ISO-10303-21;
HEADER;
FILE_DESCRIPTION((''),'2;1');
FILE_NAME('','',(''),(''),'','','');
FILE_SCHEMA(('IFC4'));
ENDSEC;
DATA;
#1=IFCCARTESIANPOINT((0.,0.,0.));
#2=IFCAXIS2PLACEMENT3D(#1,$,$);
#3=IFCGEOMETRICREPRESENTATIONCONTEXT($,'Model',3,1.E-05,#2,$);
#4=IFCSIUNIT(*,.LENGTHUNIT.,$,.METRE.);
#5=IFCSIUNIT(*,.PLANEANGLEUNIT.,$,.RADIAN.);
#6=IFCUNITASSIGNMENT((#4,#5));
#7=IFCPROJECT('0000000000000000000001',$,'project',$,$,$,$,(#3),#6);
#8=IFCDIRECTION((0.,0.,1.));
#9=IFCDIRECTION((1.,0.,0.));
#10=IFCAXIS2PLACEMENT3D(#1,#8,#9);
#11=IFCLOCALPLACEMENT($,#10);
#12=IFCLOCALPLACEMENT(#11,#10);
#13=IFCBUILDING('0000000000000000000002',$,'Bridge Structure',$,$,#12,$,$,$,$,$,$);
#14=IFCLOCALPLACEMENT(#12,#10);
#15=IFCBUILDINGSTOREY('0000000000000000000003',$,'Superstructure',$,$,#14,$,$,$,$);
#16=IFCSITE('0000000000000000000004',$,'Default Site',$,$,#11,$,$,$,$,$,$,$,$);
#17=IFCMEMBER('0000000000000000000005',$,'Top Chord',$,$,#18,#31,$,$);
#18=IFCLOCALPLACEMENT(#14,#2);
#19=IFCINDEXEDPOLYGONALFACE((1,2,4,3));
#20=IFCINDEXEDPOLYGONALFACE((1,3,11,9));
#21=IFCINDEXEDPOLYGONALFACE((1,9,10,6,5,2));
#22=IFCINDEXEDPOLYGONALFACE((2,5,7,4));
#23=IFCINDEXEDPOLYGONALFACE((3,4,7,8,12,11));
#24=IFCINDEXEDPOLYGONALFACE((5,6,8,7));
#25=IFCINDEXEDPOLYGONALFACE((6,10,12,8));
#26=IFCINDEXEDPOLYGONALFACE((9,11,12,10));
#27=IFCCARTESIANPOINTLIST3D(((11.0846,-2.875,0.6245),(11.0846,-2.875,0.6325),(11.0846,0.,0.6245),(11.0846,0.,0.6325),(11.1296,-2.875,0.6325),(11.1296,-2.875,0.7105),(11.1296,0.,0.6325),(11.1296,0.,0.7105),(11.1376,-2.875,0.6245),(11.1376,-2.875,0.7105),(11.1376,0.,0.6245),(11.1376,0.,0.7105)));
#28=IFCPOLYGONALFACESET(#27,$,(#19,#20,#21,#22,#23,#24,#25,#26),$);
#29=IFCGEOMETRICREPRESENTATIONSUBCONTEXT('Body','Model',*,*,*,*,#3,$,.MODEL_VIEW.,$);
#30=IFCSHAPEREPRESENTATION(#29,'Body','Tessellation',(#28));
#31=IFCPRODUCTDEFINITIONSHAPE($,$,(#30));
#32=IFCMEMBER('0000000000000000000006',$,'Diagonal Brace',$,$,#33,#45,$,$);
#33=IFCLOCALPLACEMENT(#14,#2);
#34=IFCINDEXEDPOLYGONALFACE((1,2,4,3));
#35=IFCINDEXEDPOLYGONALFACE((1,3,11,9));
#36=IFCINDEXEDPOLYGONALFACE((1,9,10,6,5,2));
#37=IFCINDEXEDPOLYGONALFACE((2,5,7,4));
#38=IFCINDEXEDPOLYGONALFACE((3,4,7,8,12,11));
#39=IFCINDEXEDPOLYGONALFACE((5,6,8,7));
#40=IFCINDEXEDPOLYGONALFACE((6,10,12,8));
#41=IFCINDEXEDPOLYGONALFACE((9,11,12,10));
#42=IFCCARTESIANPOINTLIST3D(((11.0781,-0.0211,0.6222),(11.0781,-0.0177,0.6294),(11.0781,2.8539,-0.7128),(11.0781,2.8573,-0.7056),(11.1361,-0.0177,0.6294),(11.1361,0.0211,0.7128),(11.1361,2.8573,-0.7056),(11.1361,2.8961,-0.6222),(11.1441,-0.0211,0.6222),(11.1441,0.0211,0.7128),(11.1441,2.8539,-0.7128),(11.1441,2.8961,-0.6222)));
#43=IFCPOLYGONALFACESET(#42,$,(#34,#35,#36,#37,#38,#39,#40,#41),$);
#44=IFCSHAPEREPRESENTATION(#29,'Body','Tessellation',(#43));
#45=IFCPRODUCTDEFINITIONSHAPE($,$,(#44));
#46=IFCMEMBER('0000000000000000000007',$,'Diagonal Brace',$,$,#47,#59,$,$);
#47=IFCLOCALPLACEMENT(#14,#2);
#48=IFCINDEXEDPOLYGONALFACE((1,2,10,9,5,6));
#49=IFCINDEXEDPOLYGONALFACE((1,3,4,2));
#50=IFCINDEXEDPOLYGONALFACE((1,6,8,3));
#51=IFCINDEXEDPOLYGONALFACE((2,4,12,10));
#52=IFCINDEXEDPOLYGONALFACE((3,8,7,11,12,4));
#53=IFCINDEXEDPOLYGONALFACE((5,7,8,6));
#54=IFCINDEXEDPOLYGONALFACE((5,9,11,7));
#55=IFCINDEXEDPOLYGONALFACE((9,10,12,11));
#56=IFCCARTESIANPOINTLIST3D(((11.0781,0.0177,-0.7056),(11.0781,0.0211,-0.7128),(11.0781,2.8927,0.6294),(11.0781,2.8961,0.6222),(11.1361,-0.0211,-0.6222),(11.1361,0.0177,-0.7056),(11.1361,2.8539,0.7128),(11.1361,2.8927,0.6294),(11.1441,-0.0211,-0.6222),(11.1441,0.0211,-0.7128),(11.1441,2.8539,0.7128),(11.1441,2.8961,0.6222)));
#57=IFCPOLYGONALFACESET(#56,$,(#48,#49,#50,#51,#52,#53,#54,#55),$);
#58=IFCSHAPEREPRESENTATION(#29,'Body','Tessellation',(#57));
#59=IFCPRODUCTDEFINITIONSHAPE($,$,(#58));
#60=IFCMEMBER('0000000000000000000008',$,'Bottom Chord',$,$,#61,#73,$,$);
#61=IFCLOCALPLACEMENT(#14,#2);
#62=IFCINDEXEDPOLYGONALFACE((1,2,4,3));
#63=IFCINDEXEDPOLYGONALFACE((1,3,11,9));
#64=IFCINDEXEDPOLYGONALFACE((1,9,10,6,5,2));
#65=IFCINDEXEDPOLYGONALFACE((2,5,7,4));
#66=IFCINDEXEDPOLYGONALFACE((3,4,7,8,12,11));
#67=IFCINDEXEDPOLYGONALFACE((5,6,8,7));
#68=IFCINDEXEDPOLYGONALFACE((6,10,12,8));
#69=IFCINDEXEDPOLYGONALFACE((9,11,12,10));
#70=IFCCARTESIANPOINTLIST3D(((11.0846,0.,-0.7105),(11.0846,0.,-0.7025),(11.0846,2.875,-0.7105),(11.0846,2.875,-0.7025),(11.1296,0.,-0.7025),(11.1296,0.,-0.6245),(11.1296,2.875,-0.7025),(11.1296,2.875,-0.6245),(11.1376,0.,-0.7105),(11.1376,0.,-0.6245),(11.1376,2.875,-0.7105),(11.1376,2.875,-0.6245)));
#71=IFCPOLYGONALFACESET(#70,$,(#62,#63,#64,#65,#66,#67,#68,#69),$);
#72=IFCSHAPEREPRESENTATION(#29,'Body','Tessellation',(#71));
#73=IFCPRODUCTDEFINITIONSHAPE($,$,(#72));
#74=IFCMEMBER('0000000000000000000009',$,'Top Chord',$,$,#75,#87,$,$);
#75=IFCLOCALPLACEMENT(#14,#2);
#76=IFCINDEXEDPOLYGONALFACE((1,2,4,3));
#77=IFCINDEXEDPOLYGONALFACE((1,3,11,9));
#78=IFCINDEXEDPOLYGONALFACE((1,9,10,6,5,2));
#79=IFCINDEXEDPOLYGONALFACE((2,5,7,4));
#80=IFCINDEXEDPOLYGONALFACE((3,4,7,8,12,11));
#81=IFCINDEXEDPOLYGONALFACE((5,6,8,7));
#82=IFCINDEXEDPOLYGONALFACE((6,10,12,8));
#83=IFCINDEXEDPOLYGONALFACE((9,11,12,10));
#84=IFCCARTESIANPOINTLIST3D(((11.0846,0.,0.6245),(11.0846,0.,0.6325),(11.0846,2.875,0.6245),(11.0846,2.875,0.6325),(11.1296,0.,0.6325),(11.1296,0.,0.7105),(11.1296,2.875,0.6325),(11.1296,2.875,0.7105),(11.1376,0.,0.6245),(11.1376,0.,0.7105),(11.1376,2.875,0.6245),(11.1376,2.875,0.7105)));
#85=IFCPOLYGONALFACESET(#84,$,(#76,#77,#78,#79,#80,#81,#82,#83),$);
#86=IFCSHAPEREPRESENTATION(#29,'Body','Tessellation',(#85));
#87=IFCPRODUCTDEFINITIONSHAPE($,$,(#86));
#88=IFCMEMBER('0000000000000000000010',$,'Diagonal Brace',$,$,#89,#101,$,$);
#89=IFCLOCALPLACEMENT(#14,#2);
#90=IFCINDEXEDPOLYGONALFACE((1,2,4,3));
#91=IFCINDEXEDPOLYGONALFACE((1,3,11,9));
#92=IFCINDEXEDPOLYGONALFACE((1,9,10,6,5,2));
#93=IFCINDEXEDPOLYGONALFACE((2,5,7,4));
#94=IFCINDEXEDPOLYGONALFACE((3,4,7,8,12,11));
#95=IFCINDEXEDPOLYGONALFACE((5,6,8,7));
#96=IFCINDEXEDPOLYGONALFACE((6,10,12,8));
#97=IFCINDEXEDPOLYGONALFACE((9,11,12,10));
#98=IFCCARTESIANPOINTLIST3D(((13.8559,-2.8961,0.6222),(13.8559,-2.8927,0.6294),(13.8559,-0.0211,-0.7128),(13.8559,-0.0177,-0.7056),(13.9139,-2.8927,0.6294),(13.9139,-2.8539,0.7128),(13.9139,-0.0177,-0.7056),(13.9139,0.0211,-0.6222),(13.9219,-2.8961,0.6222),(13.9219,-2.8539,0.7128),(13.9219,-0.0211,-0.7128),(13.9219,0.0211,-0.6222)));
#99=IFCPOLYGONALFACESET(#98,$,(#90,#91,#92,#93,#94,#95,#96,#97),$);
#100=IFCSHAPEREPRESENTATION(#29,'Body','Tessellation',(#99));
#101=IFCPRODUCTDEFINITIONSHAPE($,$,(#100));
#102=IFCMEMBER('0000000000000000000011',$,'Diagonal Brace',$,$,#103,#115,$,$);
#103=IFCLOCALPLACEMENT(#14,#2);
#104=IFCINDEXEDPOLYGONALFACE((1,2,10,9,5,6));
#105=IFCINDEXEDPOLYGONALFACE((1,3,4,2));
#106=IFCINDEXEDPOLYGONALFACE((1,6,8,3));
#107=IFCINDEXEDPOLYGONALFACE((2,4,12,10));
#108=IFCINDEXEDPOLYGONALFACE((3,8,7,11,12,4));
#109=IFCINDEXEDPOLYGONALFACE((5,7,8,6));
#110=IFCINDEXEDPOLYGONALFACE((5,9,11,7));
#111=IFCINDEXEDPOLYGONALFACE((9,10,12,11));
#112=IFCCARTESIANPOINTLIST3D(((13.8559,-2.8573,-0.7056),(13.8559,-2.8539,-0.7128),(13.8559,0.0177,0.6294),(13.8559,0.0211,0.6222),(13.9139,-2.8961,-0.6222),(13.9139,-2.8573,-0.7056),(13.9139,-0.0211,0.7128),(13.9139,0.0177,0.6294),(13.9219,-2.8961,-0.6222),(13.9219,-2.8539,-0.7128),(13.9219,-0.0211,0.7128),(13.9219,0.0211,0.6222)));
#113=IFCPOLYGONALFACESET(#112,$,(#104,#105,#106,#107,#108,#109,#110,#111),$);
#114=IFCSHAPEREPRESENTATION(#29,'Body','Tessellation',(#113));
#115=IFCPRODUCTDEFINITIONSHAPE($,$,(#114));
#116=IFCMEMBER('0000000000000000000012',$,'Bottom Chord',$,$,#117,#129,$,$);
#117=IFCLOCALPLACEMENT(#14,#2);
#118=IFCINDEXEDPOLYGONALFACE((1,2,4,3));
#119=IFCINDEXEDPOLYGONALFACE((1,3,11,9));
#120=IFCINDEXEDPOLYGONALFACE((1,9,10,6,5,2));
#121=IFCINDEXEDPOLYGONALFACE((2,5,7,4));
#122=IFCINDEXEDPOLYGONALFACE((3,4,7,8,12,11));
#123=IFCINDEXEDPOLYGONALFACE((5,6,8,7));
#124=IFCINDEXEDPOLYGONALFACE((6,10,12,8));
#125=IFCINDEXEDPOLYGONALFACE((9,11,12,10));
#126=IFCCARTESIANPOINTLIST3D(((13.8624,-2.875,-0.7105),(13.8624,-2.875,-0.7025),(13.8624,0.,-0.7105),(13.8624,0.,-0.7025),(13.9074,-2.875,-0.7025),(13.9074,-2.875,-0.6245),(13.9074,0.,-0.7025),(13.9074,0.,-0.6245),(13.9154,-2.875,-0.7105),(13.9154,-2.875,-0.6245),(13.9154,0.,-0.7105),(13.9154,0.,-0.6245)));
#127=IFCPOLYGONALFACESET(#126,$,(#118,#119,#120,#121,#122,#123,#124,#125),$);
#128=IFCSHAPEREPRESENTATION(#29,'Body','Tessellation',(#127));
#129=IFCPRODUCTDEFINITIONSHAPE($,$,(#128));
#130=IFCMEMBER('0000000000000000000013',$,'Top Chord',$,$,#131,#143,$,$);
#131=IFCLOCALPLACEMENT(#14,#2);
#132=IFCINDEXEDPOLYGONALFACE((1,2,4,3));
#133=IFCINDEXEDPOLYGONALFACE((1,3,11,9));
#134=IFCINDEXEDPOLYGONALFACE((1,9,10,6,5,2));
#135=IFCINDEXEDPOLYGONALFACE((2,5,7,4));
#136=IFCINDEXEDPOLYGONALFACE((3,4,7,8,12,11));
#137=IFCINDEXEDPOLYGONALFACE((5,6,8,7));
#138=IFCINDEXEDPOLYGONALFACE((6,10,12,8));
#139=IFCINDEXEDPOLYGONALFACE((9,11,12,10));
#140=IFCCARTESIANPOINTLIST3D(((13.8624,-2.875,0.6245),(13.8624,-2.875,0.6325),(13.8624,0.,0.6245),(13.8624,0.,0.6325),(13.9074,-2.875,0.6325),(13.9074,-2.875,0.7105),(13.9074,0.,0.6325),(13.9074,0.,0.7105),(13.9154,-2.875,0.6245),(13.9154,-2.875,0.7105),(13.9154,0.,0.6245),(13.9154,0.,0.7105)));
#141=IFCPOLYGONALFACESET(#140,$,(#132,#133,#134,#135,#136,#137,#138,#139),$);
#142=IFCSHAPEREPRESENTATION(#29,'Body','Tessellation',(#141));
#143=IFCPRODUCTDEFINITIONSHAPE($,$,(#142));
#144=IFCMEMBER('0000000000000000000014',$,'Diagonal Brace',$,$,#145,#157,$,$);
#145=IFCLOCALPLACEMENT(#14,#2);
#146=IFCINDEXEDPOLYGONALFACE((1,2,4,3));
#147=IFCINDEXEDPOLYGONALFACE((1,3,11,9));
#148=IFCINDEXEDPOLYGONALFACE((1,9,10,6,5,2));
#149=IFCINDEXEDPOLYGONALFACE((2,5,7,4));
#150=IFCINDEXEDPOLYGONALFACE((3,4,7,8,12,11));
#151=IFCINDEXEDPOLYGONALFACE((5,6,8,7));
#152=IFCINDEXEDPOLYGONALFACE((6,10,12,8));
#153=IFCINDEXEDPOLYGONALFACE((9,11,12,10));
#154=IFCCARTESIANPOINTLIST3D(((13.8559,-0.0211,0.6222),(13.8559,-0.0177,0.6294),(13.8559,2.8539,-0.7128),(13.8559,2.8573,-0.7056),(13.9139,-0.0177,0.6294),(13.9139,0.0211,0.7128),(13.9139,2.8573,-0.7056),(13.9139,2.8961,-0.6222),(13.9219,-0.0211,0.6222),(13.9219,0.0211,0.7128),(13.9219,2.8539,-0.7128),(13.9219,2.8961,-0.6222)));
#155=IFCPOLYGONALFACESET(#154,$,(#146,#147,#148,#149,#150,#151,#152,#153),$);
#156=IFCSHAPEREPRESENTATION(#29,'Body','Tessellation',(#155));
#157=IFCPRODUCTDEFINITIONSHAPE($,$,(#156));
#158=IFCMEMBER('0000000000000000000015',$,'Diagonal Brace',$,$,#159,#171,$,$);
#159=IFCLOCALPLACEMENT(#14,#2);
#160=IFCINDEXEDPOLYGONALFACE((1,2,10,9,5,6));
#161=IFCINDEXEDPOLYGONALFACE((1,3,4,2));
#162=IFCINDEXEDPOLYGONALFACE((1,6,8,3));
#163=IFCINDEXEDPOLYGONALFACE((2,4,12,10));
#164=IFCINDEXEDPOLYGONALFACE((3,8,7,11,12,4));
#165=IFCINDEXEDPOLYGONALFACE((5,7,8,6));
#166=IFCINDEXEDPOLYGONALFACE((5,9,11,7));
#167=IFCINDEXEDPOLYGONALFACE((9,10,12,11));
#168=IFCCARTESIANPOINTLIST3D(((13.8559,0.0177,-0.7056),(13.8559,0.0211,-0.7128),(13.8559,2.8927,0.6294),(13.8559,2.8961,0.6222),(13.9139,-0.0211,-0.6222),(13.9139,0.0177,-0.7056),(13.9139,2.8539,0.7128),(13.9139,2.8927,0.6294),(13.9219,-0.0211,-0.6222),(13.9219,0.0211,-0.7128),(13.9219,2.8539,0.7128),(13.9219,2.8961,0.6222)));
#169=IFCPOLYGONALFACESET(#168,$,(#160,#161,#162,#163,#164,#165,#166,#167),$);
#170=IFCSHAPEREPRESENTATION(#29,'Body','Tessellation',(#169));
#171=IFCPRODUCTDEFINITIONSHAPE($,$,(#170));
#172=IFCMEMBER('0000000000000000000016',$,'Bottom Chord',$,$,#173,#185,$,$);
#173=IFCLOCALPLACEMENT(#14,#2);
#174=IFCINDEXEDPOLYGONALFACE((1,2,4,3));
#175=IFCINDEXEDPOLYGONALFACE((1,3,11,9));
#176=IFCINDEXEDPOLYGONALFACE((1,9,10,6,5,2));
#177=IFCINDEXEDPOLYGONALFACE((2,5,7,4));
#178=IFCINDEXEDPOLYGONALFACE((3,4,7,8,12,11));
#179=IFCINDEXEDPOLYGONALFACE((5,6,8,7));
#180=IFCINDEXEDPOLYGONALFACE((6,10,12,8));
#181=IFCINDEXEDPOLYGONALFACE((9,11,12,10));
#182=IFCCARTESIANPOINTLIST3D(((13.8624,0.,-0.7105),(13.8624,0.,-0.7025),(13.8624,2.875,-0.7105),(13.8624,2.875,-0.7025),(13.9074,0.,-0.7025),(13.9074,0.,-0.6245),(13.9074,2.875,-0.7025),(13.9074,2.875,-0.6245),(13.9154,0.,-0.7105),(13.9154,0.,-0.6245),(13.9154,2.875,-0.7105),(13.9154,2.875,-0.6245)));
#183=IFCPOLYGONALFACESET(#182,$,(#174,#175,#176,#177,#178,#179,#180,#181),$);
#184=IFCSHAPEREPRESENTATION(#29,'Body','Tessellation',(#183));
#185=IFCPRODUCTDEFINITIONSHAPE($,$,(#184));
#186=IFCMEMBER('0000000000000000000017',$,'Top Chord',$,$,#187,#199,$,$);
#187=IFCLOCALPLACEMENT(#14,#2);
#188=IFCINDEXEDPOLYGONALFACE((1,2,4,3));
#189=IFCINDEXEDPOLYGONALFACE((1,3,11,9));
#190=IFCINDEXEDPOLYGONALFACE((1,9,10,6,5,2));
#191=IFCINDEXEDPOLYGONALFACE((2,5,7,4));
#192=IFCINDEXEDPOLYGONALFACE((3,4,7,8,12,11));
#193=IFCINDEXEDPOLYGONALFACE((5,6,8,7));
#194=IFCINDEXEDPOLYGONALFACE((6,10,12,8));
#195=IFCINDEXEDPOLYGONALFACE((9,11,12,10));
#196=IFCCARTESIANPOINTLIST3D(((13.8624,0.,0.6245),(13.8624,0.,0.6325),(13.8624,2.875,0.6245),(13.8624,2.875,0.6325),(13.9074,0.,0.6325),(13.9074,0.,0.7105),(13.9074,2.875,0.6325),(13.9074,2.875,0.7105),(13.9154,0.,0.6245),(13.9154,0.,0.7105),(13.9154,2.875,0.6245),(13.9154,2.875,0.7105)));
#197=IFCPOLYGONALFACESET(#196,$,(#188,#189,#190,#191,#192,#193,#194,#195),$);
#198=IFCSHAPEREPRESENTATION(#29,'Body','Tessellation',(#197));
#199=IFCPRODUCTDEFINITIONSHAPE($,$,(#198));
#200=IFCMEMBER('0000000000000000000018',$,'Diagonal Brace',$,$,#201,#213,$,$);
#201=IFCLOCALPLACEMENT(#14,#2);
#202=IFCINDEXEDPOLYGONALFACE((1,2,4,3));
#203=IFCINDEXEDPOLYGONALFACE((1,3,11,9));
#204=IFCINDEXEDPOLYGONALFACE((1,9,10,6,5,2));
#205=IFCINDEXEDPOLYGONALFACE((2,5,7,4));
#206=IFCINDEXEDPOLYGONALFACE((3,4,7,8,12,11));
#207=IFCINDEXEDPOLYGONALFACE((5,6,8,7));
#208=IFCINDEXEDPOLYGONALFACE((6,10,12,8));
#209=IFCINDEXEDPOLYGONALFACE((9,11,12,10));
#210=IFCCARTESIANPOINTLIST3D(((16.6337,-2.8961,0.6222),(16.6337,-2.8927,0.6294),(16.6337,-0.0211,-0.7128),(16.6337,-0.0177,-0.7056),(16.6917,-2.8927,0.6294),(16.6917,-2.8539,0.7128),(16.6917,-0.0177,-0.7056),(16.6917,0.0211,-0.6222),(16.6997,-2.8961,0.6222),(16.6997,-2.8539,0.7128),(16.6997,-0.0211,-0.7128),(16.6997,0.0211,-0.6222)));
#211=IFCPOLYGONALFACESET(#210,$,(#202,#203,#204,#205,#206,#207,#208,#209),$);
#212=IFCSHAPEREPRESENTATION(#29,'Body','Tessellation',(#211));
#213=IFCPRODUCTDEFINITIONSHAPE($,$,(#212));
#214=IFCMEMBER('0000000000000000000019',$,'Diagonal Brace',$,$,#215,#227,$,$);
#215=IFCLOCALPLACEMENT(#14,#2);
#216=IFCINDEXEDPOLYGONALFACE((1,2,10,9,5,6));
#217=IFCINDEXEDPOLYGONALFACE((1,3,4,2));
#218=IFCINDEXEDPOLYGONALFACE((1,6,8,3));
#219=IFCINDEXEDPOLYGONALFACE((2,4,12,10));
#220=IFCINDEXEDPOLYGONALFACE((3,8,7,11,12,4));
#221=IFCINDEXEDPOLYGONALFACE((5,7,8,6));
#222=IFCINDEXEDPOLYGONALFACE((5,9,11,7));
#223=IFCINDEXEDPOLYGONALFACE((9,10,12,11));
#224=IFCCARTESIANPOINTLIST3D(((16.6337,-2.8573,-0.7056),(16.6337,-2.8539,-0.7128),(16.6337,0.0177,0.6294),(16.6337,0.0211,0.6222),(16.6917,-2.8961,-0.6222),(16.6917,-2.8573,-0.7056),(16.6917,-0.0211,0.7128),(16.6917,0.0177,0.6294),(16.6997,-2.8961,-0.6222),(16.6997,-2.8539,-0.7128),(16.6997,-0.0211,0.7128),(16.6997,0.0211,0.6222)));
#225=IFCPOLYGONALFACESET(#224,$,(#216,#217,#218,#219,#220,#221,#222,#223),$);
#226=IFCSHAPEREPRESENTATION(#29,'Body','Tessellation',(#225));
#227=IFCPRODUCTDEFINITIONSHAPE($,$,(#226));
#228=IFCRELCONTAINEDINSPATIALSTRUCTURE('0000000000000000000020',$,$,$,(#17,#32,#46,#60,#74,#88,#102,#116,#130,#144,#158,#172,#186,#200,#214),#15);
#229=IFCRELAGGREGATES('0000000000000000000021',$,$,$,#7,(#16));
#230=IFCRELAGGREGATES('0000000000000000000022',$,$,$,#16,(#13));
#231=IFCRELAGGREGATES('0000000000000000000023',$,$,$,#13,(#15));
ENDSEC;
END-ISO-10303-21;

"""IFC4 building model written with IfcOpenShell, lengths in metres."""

from ifc_helpers import new_model, si_unit, frame, origin, origin_with_axes, origin_2d_with_axis, place, context, subcontext, project, spatial, l_section, extrude, element, save


model = new_model("IFC4")

# Units and contexts
model_context = context("Model", 3, precision=1e-05, world=origin())
body_context = subcontext(model_context, "Body", "Model", "MODEL_VIEW")
ifc_project = project(units=[si_unit("LENGTHUNIT", "METRE"), si_unit("PLANEANGLEUNIT", "RADIAN")], contexts=[model_context])

# Site, building, storey
site_placement = place(None, origin_with_axes())
site = spatial("IfcSite", under=ifc_project, at=site_placement, Name="Default Site")
building_placement = place(site_placement, origin_with_axes())
building = spatial("IfcBuilding", under=site, at=building_placement, Name="Bridge Structure")
storey_placement = place(building_placement, origin_with_axes())
storey = spatial("IfcBuildingStorey", under=building, at=storey_placement, Name="Superstructure")

# Members
member_placement = place(storey_placement, frame((11.1111, -2.875, 0.6675), z_axis=(0.0, 1.0, 0.0), x_axis=(-1.0, 0.0, 0.0)))
element("IfcMember", 1, at=member_placement, inside=storey, Name="Top Chord", context=body_context, shape_type="SweptSolid", body=[
    extrude(l_section(Depth=0.086, Width=0.053, Thickness=0.008, at=origin_2d_with_axis()), origin_with_axes(), (0.0, 0.0, 1.0), 2.875),
])
for number, where, z_axis, x_axis, name in (
    (2, (11.1111, 0.0, 0.6675), (0.0, 0.906987, -0.421158), (-1.0, 0.0, 0.0), "Diagonal Brace"),
    (3, (11.1111, 0.0, -0.6675), (0.0, 0.906987, 0.421158), (-1.0, 0.0, 0.0), "Diagonal Brace"),
):
    element("IfcMember", number, at=place(storey_placement, frame(where, z_axis=z_axis, x_axis=x_axis)), inside=storey, Name=name, context=body_context, shape_type="SweptSolid", body=[
        extrude(l_section(Depth=0.1, Width=0.066, Thickness=0.008, at=origin_2d_with_axis()), origin_with_axes(), (0.0, 0.0, 1.0), 3.1698),
    ])
for number, where, z_axis, x_axis, name in (
    (4, (11.1111, 0.0, -0.6675), (0.0, 1.0, 0.0), (-1.0, 0.0, 0.0), "Bottom Chord"),
    (5, (11.1111, 0.0, 0.6675), (0.0, 1.0, 0.0), (-1.0, 0.0, 0.0), "Top Chord"),
):
    element("IfcMember", number, at=place(storey_placement, frame(where, z_axis=z_axis, x_axis=x_axis)), inside=storey, Name=name, context=body_context, shape_type="SweptSolid", body=[
        extrude(l_section(Depth=0.086, Width=0.053, Thickness=0.008, at=origin_2d_with_axis()), origin_with_axes(), (0.0, 0.0, 1.0), 2.875),
    ])
for number, where, z_axis, x_axis, name in (
    (6, (13.8889, -2.875, 0.6675), (0.0, 0.906987, -0.421158), (-1.0, 0.0, 0.0), "Diagonal Brace"),
    (7, (13.8889, -2.875, -0.6675), (0.0, 0.906987, 0.421158), (-1.0, 0.0, 0.0), "Diagonal Brace"),
):
    element("IfcMember", number, at=place(storey_placement, frame(where, z_axis=z_axis, x_axis=x_axis)), inside=storey, Name=name, context=body_context, shape_type="SweptSolid", body=[
        extrude(l_section(Depth=0.1, Width=0.066, Thickness=0.008, at=origin_2d_with_axis()), origin_with_axes(), (0.0, 0.0, 1.0), 3.1698),
    ])
for number, where, z_axis, x_axis, name in (
    (8, (13.8889, -2.875, -0.6675), (0.0, 1.0, 0.0), (-1.0, 0.0, 0.0), "Bottom Chord"),
    (9, (13.8889, -2.875, 0.6675), (0.0, 1.0, 0.0), (-1.0, 0.0, 0.0), "Top Chord"),
):
    element("IfcMember", number, at=place(storey_placement, frame(where, z_axis=z_axis, x_axis=x_axis)), inside=storey, Name=name, context=body_context, shape_type="SweptSolid", body=[
        extrude(l_section(Depth=0.086, Width=0.053, Thickness=0.008, at=origin_2d_with_axis()), origin_with_axes(), (0.0, 0.0, 1.0), 2.875),
    ])
for number, where, z_axis, x_axis, name in (
    (10, (13.8889, 0.0, 0.6675), (0.0, 0.906987, -0.421158), (-1.0, 0.0, 0.0), "Diagonal Brace"),
    (11, (13.8889, 0.0, -0.6675), (0.0, 0.906987, 0.421158), (-1.0, 0.0, 0.0), "Diagonal Brace"),
):
    element("IfcMember", number, at=place(storey_placement, frame(where, z_axis=z_axis, x_axis=x_axis)), inside=storey, Name=name, context=body_context, shape_type="SweptSolid", body=[
        extrude(l_section(Depth=0.1, Width=0.066, Thickness=0.008, at=origin_2d_with_axis()), origin_with_axes(), (0.0, 0.0, 1.0), 3.1698),
    ])
for number, where, z_axis, x_axis, name in (
    (12, (13.8889, 0.0, -0.6675), (0.0, 1.0, 0.0), (-1.0, 0.0, 0.0), "Bottom Chord"),
    (13, (13.8889, 0.0, 0.6675), (0.0, 1.0, 0.0), (-1.0, 0.0, 0.0), "Top Chord"),
):
    element("IfcMember", number, at=place(storey_placement, frame(where, z_axis=z_axis, x_axis=x_axis)), inside=storey, Name=name, context=body_context, shape_type="SweptSolid", body=[
        extrude(l_section(Depth=0.086, Width=0.053, Thickness=0.008, at=origin_2d_with_axis()), origin_with_axes(), (0.0, 0.0, 1.0), 2.875),
    ])
for number, where, z_axis, x_axis, name in (
    (14, (16.6667, -2.875, 0.6675), (0.0, 0.906987, -0.421158), (-1.0, 0.0, 0.0), "Diagonal Brace"),
    (15, (16.6667, -2.875, -0.6675), (0.0, 0.906987, 0.421158), (-1.0, 0.0, 0.0), "Diagonal Brace"),
):
    element("IfcMember", number, at=place(storey_placement, frame(where, z_axis=z_axis, x_axis=x_axis)), inside=storey, Name=name, context=body_context, shape_type="SweptSolid", body=[
        extrude(l_section(Depth=0.1, Width=0.066, Thickness=0.008, at=origin_2d_with_axis()), origin_with_axes(), (0.0, 0.0, 1.0), 3.1698),
    ])

save(model, "model.ifc")
